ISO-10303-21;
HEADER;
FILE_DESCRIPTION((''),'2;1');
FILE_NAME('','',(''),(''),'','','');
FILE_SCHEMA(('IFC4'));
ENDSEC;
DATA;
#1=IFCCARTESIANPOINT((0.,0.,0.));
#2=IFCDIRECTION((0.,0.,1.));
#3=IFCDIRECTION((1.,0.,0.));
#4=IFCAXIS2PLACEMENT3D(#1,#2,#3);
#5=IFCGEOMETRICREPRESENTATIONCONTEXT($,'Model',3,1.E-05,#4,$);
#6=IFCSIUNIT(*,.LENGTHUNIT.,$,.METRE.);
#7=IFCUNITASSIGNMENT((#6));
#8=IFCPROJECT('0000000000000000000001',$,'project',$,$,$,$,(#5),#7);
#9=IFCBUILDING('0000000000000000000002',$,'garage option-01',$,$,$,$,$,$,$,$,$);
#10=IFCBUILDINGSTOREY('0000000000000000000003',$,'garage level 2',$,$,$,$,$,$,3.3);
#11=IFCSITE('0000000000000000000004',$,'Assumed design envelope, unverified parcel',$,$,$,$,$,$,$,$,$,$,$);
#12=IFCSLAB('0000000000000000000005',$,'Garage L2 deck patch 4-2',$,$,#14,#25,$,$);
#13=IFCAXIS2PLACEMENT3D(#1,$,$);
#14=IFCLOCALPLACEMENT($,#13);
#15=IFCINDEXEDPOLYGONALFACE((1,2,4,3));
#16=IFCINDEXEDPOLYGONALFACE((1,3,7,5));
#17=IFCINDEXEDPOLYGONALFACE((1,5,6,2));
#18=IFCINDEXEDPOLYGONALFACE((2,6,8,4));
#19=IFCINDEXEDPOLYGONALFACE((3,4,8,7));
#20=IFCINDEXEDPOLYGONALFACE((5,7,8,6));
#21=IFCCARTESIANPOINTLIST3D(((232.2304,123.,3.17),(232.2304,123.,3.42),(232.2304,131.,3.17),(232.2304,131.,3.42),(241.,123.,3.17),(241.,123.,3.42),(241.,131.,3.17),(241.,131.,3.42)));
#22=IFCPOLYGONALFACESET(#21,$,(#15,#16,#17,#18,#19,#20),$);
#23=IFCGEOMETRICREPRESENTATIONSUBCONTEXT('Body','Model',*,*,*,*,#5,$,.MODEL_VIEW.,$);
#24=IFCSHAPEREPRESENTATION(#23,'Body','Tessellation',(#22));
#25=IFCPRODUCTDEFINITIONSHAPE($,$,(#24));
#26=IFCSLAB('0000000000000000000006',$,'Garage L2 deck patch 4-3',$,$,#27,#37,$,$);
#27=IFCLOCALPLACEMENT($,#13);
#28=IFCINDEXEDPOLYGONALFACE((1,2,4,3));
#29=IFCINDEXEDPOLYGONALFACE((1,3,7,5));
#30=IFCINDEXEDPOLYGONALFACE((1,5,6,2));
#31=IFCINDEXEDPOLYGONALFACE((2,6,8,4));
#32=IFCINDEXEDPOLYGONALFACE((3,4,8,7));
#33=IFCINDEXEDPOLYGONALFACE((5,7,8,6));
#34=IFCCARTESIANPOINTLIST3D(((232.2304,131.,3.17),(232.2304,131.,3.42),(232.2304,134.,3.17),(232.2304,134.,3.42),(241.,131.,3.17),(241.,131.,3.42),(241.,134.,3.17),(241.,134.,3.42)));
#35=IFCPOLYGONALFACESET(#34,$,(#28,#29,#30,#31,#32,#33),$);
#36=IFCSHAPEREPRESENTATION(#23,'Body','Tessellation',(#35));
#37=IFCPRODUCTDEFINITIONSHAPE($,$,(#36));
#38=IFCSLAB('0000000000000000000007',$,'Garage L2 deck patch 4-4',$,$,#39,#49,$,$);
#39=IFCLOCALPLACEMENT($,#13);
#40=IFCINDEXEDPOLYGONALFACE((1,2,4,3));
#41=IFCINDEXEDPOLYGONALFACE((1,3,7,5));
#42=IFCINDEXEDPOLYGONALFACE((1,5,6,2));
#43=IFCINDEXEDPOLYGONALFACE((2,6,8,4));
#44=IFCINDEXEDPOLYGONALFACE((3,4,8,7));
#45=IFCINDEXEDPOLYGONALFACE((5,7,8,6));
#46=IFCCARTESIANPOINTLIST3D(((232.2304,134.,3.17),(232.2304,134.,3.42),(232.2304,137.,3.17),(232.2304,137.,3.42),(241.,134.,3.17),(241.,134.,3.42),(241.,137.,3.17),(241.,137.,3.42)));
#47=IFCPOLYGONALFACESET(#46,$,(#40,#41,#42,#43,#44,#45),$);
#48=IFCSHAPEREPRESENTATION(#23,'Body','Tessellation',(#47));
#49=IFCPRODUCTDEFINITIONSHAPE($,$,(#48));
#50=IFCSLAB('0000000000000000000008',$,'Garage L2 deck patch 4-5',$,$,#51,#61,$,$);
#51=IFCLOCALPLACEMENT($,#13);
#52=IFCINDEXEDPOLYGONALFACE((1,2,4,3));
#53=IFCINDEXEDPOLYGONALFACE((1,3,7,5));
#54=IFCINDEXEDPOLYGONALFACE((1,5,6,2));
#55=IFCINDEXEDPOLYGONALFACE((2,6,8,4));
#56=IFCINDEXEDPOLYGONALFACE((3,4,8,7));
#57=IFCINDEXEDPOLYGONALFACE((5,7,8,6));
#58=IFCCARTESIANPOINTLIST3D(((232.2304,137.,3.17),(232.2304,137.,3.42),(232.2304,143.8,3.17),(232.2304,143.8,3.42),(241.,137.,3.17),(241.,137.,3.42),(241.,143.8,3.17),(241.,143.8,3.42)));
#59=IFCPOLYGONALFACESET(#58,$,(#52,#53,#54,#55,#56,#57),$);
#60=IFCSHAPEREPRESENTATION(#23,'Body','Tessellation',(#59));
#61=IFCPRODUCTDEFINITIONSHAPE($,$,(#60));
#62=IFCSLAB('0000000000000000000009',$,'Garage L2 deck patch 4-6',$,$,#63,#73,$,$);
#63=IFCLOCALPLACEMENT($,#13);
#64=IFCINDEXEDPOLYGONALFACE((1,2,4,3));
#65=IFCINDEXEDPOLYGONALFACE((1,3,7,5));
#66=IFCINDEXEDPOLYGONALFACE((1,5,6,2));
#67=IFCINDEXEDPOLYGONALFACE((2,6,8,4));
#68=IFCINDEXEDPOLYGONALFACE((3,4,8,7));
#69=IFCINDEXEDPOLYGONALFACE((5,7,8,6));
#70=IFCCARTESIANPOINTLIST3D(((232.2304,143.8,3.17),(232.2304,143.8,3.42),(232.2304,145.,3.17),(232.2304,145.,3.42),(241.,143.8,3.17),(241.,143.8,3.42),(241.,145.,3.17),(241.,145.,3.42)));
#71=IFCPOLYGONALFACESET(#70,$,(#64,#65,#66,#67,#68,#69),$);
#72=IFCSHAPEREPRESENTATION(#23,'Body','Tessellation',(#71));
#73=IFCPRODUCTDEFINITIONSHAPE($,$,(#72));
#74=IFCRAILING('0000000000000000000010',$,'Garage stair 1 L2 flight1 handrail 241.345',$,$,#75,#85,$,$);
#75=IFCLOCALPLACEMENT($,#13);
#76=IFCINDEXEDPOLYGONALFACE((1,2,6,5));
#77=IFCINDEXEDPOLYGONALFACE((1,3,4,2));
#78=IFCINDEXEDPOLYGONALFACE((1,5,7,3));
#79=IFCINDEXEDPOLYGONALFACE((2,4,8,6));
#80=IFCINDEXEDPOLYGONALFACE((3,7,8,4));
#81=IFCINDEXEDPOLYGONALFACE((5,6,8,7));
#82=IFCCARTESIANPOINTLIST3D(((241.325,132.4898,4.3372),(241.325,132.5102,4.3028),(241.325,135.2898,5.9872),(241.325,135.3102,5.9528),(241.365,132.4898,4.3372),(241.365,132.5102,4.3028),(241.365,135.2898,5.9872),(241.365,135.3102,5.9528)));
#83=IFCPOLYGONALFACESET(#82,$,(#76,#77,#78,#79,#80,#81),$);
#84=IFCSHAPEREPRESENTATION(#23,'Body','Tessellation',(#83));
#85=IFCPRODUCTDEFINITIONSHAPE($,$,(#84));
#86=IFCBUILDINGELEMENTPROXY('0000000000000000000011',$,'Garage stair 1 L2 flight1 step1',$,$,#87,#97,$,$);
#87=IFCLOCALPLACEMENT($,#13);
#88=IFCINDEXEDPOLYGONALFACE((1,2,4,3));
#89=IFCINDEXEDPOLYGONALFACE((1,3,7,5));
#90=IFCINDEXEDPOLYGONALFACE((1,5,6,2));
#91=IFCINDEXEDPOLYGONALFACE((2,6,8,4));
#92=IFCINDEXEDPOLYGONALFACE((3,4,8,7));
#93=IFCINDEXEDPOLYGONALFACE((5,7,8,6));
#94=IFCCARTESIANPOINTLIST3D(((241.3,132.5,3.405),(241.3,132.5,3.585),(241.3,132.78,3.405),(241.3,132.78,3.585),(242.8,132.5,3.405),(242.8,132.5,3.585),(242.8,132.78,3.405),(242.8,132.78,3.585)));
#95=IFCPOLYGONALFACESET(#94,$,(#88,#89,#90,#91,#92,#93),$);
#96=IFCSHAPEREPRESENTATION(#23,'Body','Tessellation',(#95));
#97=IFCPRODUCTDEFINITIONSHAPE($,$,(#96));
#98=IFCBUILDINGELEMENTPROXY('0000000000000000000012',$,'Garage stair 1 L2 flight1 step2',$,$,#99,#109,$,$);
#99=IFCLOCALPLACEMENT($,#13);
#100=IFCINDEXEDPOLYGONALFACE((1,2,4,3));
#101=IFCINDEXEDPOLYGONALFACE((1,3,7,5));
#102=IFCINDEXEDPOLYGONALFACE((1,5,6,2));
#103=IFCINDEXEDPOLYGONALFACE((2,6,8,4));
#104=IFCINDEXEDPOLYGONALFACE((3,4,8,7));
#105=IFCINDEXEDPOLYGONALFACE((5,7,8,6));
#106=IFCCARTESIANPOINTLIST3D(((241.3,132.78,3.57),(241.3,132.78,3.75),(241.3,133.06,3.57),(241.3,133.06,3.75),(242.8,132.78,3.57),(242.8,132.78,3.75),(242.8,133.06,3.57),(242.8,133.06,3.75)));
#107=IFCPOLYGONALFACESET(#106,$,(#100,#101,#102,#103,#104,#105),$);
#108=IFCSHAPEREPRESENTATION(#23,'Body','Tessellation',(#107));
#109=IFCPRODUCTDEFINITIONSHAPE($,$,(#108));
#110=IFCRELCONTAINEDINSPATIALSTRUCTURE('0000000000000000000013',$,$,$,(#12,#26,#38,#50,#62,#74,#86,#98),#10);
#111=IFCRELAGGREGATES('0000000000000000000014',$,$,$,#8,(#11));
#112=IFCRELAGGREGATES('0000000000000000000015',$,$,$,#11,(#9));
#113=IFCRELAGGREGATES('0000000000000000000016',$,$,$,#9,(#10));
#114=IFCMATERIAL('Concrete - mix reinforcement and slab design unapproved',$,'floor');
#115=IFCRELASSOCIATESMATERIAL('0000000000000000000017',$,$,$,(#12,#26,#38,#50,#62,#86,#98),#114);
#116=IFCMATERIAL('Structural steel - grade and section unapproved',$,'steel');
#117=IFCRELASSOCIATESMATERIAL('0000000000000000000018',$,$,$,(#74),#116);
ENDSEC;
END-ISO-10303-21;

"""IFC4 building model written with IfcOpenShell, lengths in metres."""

from ifc_helpers import new_model, si_unit, frame, origin_with_axes, place, context, subcontext, project, spatial, rectangle, extrude, material, element, save


model = new_model("IFC4")

# Units and contexts
model_context = context("Model", 3, precision=1e-05, world=origin_with_axes())
body_context = subcontext(model_context, "Body", "Model", "MODEL_VIEW")
ifc_project = project(units=[si_unit("LENGTHUNIT", "METRE")], contexts=[model_context])

# Site, building, storey
site = spatial("IfcSite", under=ifc_project, Name="Assumed design envelope, unverified parcel")
building = spatial("IfcBuilding", under=site, Name="garage option-01")
storey = spatial("IfcBuildingStorey", under=building, Name="garage level 2", Elevation=3.3)

# Slabs
ifc_material_1 = material(Name="Concrete - mix reinforcement and slab design unapproved", Category="floor")
slab_1_placement = place(None, frame((236.6152, 127.0, 3.17), z_axis=(0.0, 0.0, 1.0), x_axis=(1.0, 0.0, 0.0)))
element("IfcSlab", 1, at=slab_1_placement, inside=storey, material=ifc_material_1, Name="Garage L2 deck patch 4-2", context=body_context, shape_type="SweptSolid", body=[
    extrude(rectangle(XDim=8.7696, YDim=8.0), origin_with_axes(), (0.0, 0.0, 1.0), 0.25),
])
for number, where, z_axis, x_axis, name in (
    (2, (236.6152, 132.5, 3.17), (0.0, 0.0, 1.0), (1.0, 0.0, 0.0), "Garage L2 deck patch 4-3"),
    (3, (236.6152, 135.5, 3.17), (0.0, 0.0, 1.0), (1.0, 0.0, 0.0), "Garage L2 deck patch 4-4"),
):
    element("IfcSlab", number, at=place(None, frame(where, z_axis=z_axis, x_axis=x_axis)), inside=storey, material=ifc_material_1, Name=name, context=body_context, shape_type="SweptSolid", body=[
        extrude(rectangle(XDim=8.7696, YDim=3.0), origin_with_axes(), (0.0, 0.0, 1.0), 0.25),
    ])
slab_2_placement = place(None, frame((236.6152, 140.4, 3.17), z_axis=(0.0, 0.0, 1.0), x_axis=(1.0, 0.0, 0.0)))
element("IfcSlab", 4, at=slab_2_placement, inside=storey, material=ifc_material_1, Name="Garage L2 deck patch 4-5", context=body_context, shape_type="SweptSolid", body=[
    extrude(rectangle(XDim=8.7696, YDim=6.8), origin_with_axes(), (0.0, 0.0, 1.0), 0.25),
])
slab_3_placement = place(None, frame((236.6152, 144.4, 3.17), z_axis=(0.0, 0.0, 1.0), x_axis=(1.0, 0.0, 0.0)))
element("IfcSlab", 5, at=slab_3_placement, inside=storey, material=ifc_material_1, Name="Garage L2 deck patch 4-6", context=body_context, shape_type="SweptSolid", body=[
    extrude(rectangle(XDim=8.7696, YDim=1.2), origin_with_axes(), (0.0, 0.0, 1.0), 0.25),
])

# Railing
ifc_material_2 = material(Name="Structural steel - grade and section unapproved", Category="steel")
railing_placement = place(None, frame((241.345, 132.5, 4.32), z_axis=(0.0, 0.861539, 0.507692), x_axis=(-1.0, 0.0, 0.0)))
element("IfcRailing", 6, at=railing_placement, inside=storey, material=ifc_material_2, Name="Garage stair 1 L2 flight1 handrail 241.345", context=body_context, shape_type="SweptSolid", body=[
    extrude(rectangle(XDim=0.04, YDim=0.04), origin_with_axes(), (0.0, 0.0, 1.0), 3.25),
])

# Building element proxies
for number, where, z_axis, x_axis, name in (
    (7, (242.05, 132.64, 3.405), (0.0, 0.0, 1.0), (1.0, 0.0, 0.0), "Garage stair 1 L2 flight1 step1"),
    (8, (242.05, 132.92, 3.57), (0.0, 0.0, 1.0), (1.0, 0.0, 0.0), "Garage stair 1 L2 flight1 step2"),
):
    element("IfcBuildingElementProxy", number, at=place(None, frame(where, z_axis=z_axis, x_axis=x_axis)), inside=storey, material=ifc_material_1, Name=name, context=body_context, shape_type="SweptSolid", body=[
        extrude(rectangle(XDim=1.5, YDim=0.28), origin_with_axes(), (0.0, 0.0, 1.0), 0.18),
    ])

save(model, "model.ifc")
